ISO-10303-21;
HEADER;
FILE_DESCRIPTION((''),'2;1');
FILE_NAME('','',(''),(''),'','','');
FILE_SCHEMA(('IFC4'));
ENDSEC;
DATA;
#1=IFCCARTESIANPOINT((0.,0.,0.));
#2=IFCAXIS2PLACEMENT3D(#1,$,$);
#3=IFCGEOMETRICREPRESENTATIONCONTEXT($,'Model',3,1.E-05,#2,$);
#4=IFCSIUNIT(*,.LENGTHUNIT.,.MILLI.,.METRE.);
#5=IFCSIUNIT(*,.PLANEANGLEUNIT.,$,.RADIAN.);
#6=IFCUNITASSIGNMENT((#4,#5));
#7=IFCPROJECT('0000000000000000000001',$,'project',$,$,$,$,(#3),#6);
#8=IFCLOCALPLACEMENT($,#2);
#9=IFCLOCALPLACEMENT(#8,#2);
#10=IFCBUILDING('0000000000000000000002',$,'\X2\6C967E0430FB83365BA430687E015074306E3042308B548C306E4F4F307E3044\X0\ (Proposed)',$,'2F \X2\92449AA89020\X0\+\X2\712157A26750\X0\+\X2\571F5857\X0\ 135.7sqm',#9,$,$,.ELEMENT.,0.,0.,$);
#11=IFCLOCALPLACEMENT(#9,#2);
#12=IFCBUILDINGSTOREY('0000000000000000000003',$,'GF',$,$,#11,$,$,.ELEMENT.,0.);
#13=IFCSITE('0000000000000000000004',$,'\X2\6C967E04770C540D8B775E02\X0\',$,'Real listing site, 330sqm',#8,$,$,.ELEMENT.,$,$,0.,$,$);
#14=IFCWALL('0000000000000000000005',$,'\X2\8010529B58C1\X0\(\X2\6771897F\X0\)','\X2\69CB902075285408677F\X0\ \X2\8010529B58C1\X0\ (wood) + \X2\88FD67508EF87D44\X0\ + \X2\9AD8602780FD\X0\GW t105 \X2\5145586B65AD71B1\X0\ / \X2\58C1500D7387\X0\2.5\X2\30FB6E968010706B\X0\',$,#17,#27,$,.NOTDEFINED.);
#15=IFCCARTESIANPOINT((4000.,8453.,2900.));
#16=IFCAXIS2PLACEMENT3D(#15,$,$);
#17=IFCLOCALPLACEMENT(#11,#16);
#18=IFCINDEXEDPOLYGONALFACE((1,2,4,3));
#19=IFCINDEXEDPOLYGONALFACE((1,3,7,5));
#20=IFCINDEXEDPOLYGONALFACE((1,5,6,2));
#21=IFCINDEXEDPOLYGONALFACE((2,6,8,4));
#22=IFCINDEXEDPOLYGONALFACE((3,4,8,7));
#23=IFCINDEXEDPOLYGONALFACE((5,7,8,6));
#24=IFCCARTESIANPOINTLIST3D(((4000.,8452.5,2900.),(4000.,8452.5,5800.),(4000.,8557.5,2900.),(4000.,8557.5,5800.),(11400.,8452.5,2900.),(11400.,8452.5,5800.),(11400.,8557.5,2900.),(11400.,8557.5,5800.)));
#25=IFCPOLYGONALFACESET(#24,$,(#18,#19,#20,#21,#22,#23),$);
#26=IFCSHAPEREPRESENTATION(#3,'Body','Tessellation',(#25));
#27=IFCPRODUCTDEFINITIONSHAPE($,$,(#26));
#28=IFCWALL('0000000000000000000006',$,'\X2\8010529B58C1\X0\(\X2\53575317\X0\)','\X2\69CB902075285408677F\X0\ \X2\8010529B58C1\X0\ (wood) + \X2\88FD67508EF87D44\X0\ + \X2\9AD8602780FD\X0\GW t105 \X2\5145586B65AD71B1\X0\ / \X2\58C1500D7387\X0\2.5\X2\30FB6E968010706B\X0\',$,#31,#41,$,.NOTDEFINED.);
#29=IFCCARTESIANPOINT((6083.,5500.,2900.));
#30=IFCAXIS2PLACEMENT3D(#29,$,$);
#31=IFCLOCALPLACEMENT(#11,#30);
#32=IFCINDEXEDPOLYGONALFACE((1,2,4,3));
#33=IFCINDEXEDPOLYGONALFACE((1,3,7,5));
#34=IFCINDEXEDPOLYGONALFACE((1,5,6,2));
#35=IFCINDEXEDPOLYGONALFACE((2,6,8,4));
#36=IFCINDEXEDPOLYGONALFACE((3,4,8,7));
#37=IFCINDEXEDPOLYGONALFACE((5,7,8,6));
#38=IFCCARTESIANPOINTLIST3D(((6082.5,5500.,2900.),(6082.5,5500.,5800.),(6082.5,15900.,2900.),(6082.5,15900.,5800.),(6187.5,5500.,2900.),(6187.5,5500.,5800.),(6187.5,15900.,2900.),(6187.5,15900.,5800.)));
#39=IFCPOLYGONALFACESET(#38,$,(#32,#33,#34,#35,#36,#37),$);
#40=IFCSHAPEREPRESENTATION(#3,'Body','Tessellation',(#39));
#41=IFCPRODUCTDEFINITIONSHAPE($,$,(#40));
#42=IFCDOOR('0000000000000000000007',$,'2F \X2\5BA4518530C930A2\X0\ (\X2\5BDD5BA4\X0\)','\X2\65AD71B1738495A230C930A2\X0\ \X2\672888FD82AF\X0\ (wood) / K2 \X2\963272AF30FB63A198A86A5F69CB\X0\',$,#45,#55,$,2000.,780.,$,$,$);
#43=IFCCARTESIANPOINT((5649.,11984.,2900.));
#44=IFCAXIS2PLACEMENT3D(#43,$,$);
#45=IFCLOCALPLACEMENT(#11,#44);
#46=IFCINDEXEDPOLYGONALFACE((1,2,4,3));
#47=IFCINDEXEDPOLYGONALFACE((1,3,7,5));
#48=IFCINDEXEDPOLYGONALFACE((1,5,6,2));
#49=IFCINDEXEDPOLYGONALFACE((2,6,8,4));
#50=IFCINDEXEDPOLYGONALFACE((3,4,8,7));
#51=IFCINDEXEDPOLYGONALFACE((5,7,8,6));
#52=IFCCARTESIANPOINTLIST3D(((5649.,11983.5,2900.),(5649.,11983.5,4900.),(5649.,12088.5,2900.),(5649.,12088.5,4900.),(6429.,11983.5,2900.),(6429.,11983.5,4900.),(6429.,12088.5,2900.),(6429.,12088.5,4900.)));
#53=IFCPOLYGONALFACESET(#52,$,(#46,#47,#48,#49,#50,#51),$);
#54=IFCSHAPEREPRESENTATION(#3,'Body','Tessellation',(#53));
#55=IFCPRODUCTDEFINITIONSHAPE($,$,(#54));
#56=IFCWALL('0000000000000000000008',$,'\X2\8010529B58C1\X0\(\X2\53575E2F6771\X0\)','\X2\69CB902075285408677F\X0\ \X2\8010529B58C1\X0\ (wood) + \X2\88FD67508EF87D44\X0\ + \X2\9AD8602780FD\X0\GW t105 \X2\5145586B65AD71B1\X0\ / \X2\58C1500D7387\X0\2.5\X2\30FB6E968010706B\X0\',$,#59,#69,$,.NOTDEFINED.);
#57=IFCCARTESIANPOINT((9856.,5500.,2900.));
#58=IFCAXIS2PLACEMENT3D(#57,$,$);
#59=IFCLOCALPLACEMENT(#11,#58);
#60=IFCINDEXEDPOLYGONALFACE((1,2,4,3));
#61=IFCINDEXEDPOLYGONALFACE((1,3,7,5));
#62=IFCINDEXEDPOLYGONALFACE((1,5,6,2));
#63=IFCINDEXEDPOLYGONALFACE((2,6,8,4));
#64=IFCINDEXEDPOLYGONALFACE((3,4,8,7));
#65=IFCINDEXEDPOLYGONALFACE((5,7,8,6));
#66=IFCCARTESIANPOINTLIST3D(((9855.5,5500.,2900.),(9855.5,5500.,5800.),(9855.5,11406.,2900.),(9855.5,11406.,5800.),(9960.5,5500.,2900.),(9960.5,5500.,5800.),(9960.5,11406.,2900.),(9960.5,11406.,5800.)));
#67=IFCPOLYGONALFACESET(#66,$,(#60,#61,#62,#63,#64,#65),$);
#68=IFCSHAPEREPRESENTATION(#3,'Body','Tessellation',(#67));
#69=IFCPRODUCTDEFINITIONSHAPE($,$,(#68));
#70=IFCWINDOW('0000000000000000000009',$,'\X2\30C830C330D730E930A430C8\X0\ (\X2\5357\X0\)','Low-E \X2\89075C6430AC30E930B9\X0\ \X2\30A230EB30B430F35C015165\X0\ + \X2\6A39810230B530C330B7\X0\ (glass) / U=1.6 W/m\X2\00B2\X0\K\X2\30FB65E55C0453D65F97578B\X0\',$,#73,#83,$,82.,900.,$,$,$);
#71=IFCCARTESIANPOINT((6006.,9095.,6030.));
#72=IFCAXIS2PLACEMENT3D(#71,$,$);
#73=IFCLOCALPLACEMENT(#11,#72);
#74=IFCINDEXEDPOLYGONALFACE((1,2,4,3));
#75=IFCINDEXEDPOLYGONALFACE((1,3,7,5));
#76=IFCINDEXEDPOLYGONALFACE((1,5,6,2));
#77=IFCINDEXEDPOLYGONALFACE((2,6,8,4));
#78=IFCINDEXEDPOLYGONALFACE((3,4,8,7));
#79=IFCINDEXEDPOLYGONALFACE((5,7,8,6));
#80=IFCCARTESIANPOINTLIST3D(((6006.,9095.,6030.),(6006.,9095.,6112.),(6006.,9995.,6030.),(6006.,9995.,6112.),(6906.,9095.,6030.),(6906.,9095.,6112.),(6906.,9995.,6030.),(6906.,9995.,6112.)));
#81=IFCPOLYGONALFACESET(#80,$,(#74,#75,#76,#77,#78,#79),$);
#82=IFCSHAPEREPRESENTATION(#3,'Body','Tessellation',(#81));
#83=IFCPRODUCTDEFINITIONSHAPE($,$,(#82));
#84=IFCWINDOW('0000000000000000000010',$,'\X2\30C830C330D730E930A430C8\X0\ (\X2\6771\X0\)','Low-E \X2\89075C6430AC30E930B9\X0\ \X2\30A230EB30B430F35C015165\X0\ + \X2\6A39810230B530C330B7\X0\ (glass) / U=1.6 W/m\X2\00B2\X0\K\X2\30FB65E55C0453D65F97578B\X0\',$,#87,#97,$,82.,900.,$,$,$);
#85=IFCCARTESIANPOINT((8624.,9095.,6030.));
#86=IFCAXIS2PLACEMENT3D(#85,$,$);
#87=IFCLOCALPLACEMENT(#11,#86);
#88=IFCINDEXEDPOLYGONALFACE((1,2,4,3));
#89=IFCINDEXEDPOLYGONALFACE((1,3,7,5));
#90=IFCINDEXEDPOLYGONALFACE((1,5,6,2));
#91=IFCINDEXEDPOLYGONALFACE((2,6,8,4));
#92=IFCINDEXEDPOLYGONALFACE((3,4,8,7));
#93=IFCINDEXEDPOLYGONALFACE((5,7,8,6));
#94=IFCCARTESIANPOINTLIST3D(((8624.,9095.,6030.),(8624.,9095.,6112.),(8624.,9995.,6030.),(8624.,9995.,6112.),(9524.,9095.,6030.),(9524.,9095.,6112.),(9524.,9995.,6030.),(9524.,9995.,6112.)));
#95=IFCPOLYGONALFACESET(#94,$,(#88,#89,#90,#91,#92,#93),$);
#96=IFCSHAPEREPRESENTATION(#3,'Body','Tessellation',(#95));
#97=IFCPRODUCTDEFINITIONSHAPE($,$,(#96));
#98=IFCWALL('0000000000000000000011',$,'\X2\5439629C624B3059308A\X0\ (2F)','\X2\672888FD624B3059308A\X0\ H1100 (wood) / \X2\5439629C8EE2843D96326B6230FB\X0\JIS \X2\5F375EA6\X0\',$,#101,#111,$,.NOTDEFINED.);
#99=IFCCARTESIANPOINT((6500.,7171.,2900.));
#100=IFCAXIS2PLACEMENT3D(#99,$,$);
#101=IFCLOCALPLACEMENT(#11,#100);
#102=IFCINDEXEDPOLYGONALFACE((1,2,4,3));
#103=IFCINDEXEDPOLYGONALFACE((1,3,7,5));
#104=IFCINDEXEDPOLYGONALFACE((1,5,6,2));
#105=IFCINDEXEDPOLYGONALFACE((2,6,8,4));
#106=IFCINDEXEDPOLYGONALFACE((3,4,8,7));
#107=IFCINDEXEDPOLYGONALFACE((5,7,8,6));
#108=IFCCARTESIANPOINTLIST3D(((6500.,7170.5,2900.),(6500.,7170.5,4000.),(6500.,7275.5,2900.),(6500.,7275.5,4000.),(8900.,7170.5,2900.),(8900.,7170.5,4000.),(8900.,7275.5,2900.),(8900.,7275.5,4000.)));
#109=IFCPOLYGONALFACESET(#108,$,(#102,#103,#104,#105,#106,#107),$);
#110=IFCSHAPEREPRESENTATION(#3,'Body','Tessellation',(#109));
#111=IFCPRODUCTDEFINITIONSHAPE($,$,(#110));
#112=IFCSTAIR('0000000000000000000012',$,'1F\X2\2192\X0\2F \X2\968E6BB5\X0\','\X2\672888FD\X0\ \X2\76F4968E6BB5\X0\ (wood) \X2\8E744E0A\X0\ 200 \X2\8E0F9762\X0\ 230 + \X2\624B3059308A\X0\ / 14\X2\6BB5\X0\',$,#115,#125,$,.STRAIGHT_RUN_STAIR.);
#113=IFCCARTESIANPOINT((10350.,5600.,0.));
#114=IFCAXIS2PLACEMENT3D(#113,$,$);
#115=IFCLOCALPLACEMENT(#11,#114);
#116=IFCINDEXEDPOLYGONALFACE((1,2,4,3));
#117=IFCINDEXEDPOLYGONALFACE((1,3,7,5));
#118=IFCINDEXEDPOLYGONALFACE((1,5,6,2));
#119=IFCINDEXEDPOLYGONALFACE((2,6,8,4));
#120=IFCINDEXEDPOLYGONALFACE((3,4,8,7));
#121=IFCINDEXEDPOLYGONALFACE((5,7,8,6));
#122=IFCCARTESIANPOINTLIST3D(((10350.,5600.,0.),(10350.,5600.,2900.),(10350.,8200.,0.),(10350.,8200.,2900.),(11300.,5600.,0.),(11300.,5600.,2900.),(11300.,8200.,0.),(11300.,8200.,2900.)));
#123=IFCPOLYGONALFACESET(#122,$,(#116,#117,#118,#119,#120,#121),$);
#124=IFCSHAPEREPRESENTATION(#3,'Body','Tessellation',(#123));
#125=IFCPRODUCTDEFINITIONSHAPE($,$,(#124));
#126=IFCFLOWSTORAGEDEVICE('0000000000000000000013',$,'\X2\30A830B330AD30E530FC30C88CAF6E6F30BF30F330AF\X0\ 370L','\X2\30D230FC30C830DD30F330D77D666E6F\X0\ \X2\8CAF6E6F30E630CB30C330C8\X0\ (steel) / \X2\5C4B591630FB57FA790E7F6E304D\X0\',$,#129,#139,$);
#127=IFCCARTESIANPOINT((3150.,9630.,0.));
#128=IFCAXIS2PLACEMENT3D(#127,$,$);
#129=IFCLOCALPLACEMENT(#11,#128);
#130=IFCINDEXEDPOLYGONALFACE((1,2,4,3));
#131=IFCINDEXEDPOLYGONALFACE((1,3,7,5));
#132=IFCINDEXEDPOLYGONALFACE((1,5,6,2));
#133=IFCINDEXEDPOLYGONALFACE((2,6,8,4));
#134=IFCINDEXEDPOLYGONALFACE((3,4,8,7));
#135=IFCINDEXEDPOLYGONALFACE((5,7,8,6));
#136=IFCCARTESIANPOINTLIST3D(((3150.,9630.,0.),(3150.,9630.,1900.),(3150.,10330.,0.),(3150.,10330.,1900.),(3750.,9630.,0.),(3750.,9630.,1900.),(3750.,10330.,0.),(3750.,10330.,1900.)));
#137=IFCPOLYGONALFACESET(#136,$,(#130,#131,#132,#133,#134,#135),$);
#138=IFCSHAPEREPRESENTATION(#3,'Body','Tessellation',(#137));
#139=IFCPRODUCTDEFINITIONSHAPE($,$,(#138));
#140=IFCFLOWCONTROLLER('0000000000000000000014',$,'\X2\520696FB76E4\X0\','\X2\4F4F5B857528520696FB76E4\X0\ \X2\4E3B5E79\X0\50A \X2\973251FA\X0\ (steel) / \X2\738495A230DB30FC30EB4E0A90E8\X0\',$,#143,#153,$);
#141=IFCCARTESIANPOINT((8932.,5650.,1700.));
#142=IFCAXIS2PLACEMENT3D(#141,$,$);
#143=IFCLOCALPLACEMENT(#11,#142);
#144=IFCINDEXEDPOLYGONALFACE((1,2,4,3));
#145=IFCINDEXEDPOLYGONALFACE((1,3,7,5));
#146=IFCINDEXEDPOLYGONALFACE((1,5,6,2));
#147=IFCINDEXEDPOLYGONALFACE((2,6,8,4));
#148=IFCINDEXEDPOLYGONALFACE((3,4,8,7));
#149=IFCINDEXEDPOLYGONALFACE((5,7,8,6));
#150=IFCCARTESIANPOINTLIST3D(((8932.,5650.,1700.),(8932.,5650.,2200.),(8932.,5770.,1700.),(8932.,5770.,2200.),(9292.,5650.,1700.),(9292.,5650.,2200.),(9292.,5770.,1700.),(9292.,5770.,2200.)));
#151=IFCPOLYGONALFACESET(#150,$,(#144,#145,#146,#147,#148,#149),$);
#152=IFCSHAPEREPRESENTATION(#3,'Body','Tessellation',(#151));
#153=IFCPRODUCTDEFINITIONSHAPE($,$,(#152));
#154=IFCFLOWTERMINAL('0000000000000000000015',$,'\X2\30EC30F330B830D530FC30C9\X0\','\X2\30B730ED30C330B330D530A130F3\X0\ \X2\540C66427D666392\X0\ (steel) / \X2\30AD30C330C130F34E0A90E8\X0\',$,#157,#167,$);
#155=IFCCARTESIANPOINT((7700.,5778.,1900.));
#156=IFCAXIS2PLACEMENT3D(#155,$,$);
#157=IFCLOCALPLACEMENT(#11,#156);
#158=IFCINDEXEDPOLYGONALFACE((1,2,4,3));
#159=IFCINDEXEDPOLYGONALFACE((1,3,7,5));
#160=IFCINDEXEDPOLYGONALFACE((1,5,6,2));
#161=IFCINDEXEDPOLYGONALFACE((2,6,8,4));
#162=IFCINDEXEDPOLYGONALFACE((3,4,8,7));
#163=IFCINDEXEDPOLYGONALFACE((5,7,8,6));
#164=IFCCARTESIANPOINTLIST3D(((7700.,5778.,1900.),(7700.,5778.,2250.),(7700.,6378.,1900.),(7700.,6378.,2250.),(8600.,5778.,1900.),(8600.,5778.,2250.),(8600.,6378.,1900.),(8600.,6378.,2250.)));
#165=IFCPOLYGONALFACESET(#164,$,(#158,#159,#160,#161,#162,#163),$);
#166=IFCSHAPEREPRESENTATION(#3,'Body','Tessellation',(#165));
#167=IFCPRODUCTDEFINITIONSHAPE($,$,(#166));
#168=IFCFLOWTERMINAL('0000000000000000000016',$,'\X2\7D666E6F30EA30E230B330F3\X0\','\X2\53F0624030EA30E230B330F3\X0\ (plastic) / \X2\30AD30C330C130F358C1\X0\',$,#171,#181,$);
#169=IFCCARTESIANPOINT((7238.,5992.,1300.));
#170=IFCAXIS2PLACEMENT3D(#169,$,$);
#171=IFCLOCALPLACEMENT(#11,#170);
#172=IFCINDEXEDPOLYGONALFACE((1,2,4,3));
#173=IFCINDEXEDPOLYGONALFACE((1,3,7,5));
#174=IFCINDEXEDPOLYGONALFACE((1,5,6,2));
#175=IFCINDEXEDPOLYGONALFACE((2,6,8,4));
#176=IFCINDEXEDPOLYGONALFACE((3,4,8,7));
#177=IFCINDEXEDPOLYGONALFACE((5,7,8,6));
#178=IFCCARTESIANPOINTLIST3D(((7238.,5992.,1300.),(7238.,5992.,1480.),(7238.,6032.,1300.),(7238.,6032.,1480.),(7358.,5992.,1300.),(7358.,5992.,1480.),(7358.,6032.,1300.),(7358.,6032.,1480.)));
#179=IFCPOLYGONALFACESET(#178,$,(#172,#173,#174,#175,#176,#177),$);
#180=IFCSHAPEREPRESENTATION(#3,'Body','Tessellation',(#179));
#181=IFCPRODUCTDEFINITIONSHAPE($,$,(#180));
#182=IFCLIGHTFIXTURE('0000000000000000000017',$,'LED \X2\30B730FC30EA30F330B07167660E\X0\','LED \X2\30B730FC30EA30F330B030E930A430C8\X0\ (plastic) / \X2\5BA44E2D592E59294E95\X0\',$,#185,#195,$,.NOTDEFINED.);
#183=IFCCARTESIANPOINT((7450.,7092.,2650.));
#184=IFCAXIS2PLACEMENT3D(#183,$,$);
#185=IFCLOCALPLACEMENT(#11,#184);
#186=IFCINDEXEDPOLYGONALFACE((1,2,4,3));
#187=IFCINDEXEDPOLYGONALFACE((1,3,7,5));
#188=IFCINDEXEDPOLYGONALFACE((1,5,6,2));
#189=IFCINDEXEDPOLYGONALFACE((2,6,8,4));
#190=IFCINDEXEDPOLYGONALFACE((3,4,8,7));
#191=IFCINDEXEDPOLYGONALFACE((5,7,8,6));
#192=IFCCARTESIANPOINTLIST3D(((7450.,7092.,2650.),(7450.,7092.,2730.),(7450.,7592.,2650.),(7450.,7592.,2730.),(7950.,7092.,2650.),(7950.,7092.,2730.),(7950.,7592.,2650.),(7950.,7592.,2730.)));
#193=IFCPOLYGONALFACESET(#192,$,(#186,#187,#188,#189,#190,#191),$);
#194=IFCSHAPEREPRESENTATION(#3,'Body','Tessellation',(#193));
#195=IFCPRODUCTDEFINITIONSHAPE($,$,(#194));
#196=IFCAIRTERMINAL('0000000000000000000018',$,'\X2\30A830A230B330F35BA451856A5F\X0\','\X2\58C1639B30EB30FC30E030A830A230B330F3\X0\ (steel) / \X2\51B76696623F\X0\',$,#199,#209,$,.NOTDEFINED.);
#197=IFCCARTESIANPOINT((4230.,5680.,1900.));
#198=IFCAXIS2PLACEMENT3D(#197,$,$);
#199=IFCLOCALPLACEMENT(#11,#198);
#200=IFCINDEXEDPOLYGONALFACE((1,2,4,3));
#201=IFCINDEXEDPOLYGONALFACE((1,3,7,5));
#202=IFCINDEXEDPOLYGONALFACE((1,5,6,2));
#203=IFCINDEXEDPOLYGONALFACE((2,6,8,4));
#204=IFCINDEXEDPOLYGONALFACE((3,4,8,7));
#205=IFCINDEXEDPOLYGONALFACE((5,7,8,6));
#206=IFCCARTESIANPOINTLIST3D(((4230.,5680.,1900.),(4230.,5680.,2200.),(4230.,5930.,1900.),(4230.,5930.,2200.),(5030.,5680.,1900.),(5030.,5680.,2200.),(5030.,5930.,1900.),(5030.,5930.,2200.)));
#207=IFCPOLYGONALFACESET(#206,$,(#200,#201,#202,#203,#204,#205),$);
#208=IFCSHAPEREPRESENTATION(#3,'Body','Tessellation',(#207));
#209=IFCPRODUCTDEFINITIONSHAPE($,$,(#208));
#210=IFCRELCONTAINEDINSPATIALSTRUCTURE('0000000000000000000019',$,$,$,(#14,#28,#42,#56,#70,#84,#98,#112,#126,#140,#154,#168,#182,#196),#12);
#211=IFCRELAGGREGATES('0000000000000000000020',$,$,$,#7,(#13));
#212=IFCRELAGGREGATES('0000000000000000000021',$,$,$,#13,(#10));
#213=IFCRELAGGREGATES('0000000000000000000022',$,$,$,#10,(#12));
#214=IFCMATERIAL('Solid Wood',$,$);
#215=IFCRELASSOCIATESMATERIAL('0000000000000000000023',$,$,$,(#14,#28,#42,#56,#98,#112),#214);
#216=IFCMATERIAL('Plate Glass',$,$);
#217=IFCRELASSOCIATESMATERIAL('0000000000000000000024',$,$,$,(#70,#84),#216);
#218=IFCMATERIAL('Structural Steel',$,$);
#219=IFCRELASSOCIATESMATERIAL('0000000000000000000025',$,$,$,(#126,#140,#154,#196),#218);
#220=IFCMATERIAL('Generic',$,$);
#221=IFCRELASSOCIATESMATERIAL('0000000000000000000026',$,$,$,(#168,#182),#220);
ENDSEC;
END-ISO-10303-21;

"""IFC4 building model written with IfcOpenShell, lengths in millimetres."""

from ifc_helpers import new_model, si_unit, frame, frame_2d, origin, place, context, project, spatial, rectangle, extrude, material, element, fill, save


model = new_model("IFC4")

# Units and contexts
model_context = context("Model", 3, precision=1e-05, world=origin())
ifc_project = project(units=[si_unit("LENGTHUNIT", "METRE", prefix="MILLI"), si_unit("PLANEANGLEUNIT", "RADIAN")], contexts=[model_context])

# Site, building, storey
site_placement = place(None, origin())
site = spatial("IfcSite", under=ifc_project, at=site_placement, Name="沖縄県名護市", ObjectType="Real listing site, 330sqm", CompositionType="ELEMENT", RefElevation=0.0)
building_placement = place(site_placement, origin())
building = spatial("IfcBuilding", under=site, at=building_placement, Name="沖縄・茶室と縁側のある和の住まい (Proposed)", ObjectType="2F 鉄骨造+無垢材+土塗 135.7sqm", CompositionType="ELEMENT", ElevationOfRefHeight=0.0, ElevationOfTerrain=0.0)
storey_placement = place(building_placement, origin())
storey = spatial("IfcBuildingStorey", under=building, at=storey_placement, Name="GF", CompositionType="ELEMENT", Elevation=0.0)

# Shared definitions
ifc_material_1 = material(Name="Solid Wood")

# Wall
wall_1_placement = place(storey_placement, frame((4000.0, 8453.0, 2900.0)))
element("IfcWall", 1, at=wall_1_placement, inside=storey, material=ifc_material_1, Name="耐力壁(東西)", Description="構造用合板 耐力壁 (wood) + 製材軸組 + 高性能GW t105 充填断熱 / 壁倍率2.5・準耐火", PredefinedType="NOTDEFINED", context=model_context, shape_type="SweptSolid", body=[
    extrude(rectangle(XDim=7400.0, YDim=105.0, at=frame_2d((3700.0, 52.0))), frame((4000.0, 8453.0, 2900.0)), (0.0, 0.0, 1.0), 2900.0),
])

# Wall, opening, door
wall_2_placement = place(storey_placement, frame((6083.0, 5500.0, 2900.0)))
wall_2 = element("IfcWall", 2, at=wall_2_placement, inside=storey, material=ifc_material_1, Name="耐力壁(南北)", Description="構造用合板 耐力壁 (wood) + 製材軸組 + 高性能GW t105 充填断熱 / 壁倍率2.5・準耐火", PredefinedType="NOTDEFINED", context=model_context, shape_type="SweptSolid", body=[
    extrude(rectangle(XDim=105.0, YDim=10400.0, at=frame_2d((52.0, 5200.0))), frame((6083.0, 5500.0, 2900.0)), (0.0, 0.0, 1.0), 2900.0),
])
opening_placement = place(storey_placement, frame((5649.0, 11984.0, 2900.0)))
opening = element("IfcOpeningElement", 3, at=opening_placement, cuts=wall_2, PredefinedType="NOTDEFINED", context=model_context, shape_type="SweptSolid", body=[
    extrude(rectangle(XDim=780.0, YDim=105.0, at=frame_2d((390.0, 52.0))), frame((5649.0, 11984.0, 2900.0)), (0.0, 0.0, 1.0), 2000.0),
])
door_placement = place(storey_placement, frame((5649.0, 11984.0, 2900.0)))
door = element("IfcDoor", 4, at=door_placement, inside=storey, material=ifc_material_1, Name="2F 室内ドア (寝室)", Description="断熱玄関ドア 木製芯 (wood) / K2 防犯・採風機構", OverallHeight=2000.0, OverallWidth=780.0, context=model_context, shape_type="SweptSolid", body=[
    extrude(rectangle(XDim=780.0, YDim=105.0, at=frame_2d((390.0, 52.0))), frame((5649.0, 11984.0, 2900.0)), (0.0, 0.0, 1.0), 2000.0),
])
fill(opening, door)

# Wall
wall_3_placement = place(storey_placement, frame((9856.0, 5500.0, 2900.0)))
element("IfcWall", 5, at=wall_3_placement, inside=storey, material=ifc_material_1, Name="耐力壁(南帯東)", Description="構造用合板 耐力壁 (wood) + 製材軸組 + 高性能GW t105 充填断熱 / 壁倍率2.5・準耐火", PredefinedType="NOTDEFINED", context=model_context, shape_type="SweptSolid", body=[
    extrude(rectangle(XDim=105.0, YDim=5906.0, at=frame_2d((52.0, 2953.0))), frame((9856.0, 5500.0, 2900.0)), (0.0, 0.0, 1.0), 2900.0),
])

# Windows
ifc_material_2 = material(Name="Plate Glass")
window_1_placement = place(storey_placement, frame((6006.0, 9095.0, 6030.0)))
element("IfcWindow", 6, at=window_1_placement, inside=storey, material=ifc_material_2, Name="トップライト (南)", Description="Low-E 複層ガラス アルゴン封入 + 樹脂サッシ (glass) / U=1.6 W/m²K・日射取得型", OverallHeight=82.0, OverallWidth=900.0, context=model_context, shape_type="SweptSolid", body=[
    extrude(rectangle(XDim=900.0, YDim=900.0, at=frame_2d((450.0, 450.0))), frame((6006.0, 9095.0, 6030.0)), (0.0, 0.0, 1.0), 82.0),
])
window_2_placement = place(storey_placement, frame((8624.0, 9095.0, 6030.0)))
element("IfcWindow", 7, at=window_2_placement, inside=storey, material=ifc_material_2, Name="トップライト (東)", Description="Low-E 複層ガラス アルゴン封入 + 樹脂サッシ (glass) / U=1.6 W/m²K・日射取得型", OverallHeight=82.0, OverallWidth=900.0, context=model_context, shape_type="SweptSolid", body=[
    extrude(rectangle(XDim=900.0, YDim=900.0, at=frame_2d((450.0, 450.0))), frame((8624.0, 9095.0, 6030.0)), (0.0, 0.0, 1.0), 82.0),
])

# Wall
wall_4_placement = place(storey_placement, frame((6500.0, 7171.0, 2900.0)))
element("IfcWall", 8, at=wall_4_placement, inside=storey, material=ifc_material_1, Name="吹抜手すり (2F)", Description="木製手すり H1100 (wood) / 吹抜転落防止・JIS 強度", PredefinedType="NOTDEFINED", context=model_context, shape_type="SweptSolid", body=[
    extrude(rectangle(XDim=2400.0, YDim=105.0, at=frame_2d((1200.0, 52.0))), frame((6500.0, 7171.0, 2900.0)), (0.0, 0.0, 1.0), 1100.0),
])

# Stair
stair_placement = place(storey_placement, frame((10350.0, 5600.0, 0.0)))
element("IfcStair", 9, at=stair_placement, inside=storey, material=ifc_material_1, Name="1F→2F 階段", Description="木製 直階段 (wood) 蹴上 200 踏面 230 + 手すり / 14段", PredefinedType="STRAIGHT_RUN_STAIR", context=model_context, shape_type="SweptSolid", body=[
    extrude(rectangle(XDim=950.0, YDim=2600.0, at=frame_2d((475.0, 1300.0))), frame((10350.0, 5600.0, 0.0)), (0.0, 0.0, 1.0), 2900.0),
])

# Flow storage device
ifc_material_3 = material(Name="Structural Steel")
flow_storage_device_placement = place(storey_placement, frame((3150.0, 9630.0, 0.0)))
element("IfcFlowStorageDevice", 10, at=flow_storage_device_placement, inside=storey, material=ifc_material_3, Name="エコキュート貯湯タンク 370L", Description="ヒートポンプ給湯 貯湯ユニット (steel) / 屋外・基礎置き", context=model_context, shape_type="SweptSolid", body=[
    extrude(rectangle(XDim=600.0, YDim=700.0, at=frame_2d((300.0, 350.0))), frame((3150.0, 9630.0, 0.0)), (0.0, 0.0, 1.0), 1900.0),
])

# Flow controller
flow_controller_placement = place(storey_placement, frame((8932.0, 5650.0, 1700.0)))
element("IfcFlowController", 11, at=flow_controller_placement, inside=storey, material=ifc_material_3, Name="分電盤", Description="住宅用分電盤 主幹50A 露出 (steel) / 玄関ホール上部", context=model_context, shape_type="SweptSolid", body=[
    extrude(rectangle(XDim=360.0, YDim=120.0, at=frame_2d((180.0, 60.0))), frame((8932.0, 5650.0, 1700.0)), (0.0, 0.0, 1.0), 500.0),
])

# Flow terminals
flow_terminal_1_placement = place(storey_placement, frame((7700.0, 5778.0, 1900.0)))
element("IfcFlowTerminal", 12, at=flow_terminal_1_placement, inside=storey, material=ifc_material_3, Name="レンジフード", Description="シロッコファン 同時給排 (steel) / キッチン上部", context=model_context, shape_type="SweptSolid", body=[
    extrude(rectangle(XDim=900.0, YDim=600.0, at=frame_2d((450.0, 300.0))), frame((7700.0, 5778.0, 1900.0)), (0.0, 0.0, 1.0), 350.0),
])
ifc_material_4 = material(Name="Generic")
flow_terminal_2_placement = place(storey_placement, frame((7238.0, 5992.0, 1300.0)))
element("IfcFlowTerminal", 13, at=flow_terminal_2_placement, inside=storey, material=ifc_material_4, Name="給湯リモコン", Description="台所リモコン (plastic) / キッチン壁", context=model_context, shape_type="SweptSolid", body=[
    extrude(rectangle(XDim=120.0, YDim=40.0, at=frame_2d((60.0, 20.0))), frame((7238.0, 5992.0, 1300.0)), (0.0, 0.0, 1.0), 180.0),
])

# Light fixture
light_fixture_1_placement = place(storey_placement, frame((7450.0, 7092.0, 2650.0)))
element("IfcLightFixture", 14, at=light_fixture_1_placement, inside=storey, material=ifc_material_4, Name="LED シーリング照明", Description="LED シーリングライト (plastic) / 室中央天井", PredefinedType="NOTDEFINED", context=model_context, shape_type="SweptSolid", body=[
    extrude(rectangle(XDim=500.0, YDim=500.0, at=frame_2d((250.0, 250.0))), frame((7450.0, 7092.0, 2650.0)), (0.0, 0.0, 1.0), 80.0),
])

# Air terminal
air_terminal_1_placement = place(storey_placement, frame((4230.0, 5680.0, 1900.0)))
element("IfcAirTerminal", 15, at=air_terminal_1_placement, inside=storey, material=ifc_material_3, Name="エアコン室内機", Description="壁掛ルームエアコン (steel) / 冷暖房", PredefinedType="NOTDEFINED", context=model_context, shape_type="SweptSolid", body=[
    extrude(rectangle(XDim=800.0, YDim=250.0, at=frame_2d((400.0, 125.0))), frame((4230.0, 5680.0, 1900.0)), (0.0, 0.0, 1.0), 300.0),
])

save(model, "model.ifc")
